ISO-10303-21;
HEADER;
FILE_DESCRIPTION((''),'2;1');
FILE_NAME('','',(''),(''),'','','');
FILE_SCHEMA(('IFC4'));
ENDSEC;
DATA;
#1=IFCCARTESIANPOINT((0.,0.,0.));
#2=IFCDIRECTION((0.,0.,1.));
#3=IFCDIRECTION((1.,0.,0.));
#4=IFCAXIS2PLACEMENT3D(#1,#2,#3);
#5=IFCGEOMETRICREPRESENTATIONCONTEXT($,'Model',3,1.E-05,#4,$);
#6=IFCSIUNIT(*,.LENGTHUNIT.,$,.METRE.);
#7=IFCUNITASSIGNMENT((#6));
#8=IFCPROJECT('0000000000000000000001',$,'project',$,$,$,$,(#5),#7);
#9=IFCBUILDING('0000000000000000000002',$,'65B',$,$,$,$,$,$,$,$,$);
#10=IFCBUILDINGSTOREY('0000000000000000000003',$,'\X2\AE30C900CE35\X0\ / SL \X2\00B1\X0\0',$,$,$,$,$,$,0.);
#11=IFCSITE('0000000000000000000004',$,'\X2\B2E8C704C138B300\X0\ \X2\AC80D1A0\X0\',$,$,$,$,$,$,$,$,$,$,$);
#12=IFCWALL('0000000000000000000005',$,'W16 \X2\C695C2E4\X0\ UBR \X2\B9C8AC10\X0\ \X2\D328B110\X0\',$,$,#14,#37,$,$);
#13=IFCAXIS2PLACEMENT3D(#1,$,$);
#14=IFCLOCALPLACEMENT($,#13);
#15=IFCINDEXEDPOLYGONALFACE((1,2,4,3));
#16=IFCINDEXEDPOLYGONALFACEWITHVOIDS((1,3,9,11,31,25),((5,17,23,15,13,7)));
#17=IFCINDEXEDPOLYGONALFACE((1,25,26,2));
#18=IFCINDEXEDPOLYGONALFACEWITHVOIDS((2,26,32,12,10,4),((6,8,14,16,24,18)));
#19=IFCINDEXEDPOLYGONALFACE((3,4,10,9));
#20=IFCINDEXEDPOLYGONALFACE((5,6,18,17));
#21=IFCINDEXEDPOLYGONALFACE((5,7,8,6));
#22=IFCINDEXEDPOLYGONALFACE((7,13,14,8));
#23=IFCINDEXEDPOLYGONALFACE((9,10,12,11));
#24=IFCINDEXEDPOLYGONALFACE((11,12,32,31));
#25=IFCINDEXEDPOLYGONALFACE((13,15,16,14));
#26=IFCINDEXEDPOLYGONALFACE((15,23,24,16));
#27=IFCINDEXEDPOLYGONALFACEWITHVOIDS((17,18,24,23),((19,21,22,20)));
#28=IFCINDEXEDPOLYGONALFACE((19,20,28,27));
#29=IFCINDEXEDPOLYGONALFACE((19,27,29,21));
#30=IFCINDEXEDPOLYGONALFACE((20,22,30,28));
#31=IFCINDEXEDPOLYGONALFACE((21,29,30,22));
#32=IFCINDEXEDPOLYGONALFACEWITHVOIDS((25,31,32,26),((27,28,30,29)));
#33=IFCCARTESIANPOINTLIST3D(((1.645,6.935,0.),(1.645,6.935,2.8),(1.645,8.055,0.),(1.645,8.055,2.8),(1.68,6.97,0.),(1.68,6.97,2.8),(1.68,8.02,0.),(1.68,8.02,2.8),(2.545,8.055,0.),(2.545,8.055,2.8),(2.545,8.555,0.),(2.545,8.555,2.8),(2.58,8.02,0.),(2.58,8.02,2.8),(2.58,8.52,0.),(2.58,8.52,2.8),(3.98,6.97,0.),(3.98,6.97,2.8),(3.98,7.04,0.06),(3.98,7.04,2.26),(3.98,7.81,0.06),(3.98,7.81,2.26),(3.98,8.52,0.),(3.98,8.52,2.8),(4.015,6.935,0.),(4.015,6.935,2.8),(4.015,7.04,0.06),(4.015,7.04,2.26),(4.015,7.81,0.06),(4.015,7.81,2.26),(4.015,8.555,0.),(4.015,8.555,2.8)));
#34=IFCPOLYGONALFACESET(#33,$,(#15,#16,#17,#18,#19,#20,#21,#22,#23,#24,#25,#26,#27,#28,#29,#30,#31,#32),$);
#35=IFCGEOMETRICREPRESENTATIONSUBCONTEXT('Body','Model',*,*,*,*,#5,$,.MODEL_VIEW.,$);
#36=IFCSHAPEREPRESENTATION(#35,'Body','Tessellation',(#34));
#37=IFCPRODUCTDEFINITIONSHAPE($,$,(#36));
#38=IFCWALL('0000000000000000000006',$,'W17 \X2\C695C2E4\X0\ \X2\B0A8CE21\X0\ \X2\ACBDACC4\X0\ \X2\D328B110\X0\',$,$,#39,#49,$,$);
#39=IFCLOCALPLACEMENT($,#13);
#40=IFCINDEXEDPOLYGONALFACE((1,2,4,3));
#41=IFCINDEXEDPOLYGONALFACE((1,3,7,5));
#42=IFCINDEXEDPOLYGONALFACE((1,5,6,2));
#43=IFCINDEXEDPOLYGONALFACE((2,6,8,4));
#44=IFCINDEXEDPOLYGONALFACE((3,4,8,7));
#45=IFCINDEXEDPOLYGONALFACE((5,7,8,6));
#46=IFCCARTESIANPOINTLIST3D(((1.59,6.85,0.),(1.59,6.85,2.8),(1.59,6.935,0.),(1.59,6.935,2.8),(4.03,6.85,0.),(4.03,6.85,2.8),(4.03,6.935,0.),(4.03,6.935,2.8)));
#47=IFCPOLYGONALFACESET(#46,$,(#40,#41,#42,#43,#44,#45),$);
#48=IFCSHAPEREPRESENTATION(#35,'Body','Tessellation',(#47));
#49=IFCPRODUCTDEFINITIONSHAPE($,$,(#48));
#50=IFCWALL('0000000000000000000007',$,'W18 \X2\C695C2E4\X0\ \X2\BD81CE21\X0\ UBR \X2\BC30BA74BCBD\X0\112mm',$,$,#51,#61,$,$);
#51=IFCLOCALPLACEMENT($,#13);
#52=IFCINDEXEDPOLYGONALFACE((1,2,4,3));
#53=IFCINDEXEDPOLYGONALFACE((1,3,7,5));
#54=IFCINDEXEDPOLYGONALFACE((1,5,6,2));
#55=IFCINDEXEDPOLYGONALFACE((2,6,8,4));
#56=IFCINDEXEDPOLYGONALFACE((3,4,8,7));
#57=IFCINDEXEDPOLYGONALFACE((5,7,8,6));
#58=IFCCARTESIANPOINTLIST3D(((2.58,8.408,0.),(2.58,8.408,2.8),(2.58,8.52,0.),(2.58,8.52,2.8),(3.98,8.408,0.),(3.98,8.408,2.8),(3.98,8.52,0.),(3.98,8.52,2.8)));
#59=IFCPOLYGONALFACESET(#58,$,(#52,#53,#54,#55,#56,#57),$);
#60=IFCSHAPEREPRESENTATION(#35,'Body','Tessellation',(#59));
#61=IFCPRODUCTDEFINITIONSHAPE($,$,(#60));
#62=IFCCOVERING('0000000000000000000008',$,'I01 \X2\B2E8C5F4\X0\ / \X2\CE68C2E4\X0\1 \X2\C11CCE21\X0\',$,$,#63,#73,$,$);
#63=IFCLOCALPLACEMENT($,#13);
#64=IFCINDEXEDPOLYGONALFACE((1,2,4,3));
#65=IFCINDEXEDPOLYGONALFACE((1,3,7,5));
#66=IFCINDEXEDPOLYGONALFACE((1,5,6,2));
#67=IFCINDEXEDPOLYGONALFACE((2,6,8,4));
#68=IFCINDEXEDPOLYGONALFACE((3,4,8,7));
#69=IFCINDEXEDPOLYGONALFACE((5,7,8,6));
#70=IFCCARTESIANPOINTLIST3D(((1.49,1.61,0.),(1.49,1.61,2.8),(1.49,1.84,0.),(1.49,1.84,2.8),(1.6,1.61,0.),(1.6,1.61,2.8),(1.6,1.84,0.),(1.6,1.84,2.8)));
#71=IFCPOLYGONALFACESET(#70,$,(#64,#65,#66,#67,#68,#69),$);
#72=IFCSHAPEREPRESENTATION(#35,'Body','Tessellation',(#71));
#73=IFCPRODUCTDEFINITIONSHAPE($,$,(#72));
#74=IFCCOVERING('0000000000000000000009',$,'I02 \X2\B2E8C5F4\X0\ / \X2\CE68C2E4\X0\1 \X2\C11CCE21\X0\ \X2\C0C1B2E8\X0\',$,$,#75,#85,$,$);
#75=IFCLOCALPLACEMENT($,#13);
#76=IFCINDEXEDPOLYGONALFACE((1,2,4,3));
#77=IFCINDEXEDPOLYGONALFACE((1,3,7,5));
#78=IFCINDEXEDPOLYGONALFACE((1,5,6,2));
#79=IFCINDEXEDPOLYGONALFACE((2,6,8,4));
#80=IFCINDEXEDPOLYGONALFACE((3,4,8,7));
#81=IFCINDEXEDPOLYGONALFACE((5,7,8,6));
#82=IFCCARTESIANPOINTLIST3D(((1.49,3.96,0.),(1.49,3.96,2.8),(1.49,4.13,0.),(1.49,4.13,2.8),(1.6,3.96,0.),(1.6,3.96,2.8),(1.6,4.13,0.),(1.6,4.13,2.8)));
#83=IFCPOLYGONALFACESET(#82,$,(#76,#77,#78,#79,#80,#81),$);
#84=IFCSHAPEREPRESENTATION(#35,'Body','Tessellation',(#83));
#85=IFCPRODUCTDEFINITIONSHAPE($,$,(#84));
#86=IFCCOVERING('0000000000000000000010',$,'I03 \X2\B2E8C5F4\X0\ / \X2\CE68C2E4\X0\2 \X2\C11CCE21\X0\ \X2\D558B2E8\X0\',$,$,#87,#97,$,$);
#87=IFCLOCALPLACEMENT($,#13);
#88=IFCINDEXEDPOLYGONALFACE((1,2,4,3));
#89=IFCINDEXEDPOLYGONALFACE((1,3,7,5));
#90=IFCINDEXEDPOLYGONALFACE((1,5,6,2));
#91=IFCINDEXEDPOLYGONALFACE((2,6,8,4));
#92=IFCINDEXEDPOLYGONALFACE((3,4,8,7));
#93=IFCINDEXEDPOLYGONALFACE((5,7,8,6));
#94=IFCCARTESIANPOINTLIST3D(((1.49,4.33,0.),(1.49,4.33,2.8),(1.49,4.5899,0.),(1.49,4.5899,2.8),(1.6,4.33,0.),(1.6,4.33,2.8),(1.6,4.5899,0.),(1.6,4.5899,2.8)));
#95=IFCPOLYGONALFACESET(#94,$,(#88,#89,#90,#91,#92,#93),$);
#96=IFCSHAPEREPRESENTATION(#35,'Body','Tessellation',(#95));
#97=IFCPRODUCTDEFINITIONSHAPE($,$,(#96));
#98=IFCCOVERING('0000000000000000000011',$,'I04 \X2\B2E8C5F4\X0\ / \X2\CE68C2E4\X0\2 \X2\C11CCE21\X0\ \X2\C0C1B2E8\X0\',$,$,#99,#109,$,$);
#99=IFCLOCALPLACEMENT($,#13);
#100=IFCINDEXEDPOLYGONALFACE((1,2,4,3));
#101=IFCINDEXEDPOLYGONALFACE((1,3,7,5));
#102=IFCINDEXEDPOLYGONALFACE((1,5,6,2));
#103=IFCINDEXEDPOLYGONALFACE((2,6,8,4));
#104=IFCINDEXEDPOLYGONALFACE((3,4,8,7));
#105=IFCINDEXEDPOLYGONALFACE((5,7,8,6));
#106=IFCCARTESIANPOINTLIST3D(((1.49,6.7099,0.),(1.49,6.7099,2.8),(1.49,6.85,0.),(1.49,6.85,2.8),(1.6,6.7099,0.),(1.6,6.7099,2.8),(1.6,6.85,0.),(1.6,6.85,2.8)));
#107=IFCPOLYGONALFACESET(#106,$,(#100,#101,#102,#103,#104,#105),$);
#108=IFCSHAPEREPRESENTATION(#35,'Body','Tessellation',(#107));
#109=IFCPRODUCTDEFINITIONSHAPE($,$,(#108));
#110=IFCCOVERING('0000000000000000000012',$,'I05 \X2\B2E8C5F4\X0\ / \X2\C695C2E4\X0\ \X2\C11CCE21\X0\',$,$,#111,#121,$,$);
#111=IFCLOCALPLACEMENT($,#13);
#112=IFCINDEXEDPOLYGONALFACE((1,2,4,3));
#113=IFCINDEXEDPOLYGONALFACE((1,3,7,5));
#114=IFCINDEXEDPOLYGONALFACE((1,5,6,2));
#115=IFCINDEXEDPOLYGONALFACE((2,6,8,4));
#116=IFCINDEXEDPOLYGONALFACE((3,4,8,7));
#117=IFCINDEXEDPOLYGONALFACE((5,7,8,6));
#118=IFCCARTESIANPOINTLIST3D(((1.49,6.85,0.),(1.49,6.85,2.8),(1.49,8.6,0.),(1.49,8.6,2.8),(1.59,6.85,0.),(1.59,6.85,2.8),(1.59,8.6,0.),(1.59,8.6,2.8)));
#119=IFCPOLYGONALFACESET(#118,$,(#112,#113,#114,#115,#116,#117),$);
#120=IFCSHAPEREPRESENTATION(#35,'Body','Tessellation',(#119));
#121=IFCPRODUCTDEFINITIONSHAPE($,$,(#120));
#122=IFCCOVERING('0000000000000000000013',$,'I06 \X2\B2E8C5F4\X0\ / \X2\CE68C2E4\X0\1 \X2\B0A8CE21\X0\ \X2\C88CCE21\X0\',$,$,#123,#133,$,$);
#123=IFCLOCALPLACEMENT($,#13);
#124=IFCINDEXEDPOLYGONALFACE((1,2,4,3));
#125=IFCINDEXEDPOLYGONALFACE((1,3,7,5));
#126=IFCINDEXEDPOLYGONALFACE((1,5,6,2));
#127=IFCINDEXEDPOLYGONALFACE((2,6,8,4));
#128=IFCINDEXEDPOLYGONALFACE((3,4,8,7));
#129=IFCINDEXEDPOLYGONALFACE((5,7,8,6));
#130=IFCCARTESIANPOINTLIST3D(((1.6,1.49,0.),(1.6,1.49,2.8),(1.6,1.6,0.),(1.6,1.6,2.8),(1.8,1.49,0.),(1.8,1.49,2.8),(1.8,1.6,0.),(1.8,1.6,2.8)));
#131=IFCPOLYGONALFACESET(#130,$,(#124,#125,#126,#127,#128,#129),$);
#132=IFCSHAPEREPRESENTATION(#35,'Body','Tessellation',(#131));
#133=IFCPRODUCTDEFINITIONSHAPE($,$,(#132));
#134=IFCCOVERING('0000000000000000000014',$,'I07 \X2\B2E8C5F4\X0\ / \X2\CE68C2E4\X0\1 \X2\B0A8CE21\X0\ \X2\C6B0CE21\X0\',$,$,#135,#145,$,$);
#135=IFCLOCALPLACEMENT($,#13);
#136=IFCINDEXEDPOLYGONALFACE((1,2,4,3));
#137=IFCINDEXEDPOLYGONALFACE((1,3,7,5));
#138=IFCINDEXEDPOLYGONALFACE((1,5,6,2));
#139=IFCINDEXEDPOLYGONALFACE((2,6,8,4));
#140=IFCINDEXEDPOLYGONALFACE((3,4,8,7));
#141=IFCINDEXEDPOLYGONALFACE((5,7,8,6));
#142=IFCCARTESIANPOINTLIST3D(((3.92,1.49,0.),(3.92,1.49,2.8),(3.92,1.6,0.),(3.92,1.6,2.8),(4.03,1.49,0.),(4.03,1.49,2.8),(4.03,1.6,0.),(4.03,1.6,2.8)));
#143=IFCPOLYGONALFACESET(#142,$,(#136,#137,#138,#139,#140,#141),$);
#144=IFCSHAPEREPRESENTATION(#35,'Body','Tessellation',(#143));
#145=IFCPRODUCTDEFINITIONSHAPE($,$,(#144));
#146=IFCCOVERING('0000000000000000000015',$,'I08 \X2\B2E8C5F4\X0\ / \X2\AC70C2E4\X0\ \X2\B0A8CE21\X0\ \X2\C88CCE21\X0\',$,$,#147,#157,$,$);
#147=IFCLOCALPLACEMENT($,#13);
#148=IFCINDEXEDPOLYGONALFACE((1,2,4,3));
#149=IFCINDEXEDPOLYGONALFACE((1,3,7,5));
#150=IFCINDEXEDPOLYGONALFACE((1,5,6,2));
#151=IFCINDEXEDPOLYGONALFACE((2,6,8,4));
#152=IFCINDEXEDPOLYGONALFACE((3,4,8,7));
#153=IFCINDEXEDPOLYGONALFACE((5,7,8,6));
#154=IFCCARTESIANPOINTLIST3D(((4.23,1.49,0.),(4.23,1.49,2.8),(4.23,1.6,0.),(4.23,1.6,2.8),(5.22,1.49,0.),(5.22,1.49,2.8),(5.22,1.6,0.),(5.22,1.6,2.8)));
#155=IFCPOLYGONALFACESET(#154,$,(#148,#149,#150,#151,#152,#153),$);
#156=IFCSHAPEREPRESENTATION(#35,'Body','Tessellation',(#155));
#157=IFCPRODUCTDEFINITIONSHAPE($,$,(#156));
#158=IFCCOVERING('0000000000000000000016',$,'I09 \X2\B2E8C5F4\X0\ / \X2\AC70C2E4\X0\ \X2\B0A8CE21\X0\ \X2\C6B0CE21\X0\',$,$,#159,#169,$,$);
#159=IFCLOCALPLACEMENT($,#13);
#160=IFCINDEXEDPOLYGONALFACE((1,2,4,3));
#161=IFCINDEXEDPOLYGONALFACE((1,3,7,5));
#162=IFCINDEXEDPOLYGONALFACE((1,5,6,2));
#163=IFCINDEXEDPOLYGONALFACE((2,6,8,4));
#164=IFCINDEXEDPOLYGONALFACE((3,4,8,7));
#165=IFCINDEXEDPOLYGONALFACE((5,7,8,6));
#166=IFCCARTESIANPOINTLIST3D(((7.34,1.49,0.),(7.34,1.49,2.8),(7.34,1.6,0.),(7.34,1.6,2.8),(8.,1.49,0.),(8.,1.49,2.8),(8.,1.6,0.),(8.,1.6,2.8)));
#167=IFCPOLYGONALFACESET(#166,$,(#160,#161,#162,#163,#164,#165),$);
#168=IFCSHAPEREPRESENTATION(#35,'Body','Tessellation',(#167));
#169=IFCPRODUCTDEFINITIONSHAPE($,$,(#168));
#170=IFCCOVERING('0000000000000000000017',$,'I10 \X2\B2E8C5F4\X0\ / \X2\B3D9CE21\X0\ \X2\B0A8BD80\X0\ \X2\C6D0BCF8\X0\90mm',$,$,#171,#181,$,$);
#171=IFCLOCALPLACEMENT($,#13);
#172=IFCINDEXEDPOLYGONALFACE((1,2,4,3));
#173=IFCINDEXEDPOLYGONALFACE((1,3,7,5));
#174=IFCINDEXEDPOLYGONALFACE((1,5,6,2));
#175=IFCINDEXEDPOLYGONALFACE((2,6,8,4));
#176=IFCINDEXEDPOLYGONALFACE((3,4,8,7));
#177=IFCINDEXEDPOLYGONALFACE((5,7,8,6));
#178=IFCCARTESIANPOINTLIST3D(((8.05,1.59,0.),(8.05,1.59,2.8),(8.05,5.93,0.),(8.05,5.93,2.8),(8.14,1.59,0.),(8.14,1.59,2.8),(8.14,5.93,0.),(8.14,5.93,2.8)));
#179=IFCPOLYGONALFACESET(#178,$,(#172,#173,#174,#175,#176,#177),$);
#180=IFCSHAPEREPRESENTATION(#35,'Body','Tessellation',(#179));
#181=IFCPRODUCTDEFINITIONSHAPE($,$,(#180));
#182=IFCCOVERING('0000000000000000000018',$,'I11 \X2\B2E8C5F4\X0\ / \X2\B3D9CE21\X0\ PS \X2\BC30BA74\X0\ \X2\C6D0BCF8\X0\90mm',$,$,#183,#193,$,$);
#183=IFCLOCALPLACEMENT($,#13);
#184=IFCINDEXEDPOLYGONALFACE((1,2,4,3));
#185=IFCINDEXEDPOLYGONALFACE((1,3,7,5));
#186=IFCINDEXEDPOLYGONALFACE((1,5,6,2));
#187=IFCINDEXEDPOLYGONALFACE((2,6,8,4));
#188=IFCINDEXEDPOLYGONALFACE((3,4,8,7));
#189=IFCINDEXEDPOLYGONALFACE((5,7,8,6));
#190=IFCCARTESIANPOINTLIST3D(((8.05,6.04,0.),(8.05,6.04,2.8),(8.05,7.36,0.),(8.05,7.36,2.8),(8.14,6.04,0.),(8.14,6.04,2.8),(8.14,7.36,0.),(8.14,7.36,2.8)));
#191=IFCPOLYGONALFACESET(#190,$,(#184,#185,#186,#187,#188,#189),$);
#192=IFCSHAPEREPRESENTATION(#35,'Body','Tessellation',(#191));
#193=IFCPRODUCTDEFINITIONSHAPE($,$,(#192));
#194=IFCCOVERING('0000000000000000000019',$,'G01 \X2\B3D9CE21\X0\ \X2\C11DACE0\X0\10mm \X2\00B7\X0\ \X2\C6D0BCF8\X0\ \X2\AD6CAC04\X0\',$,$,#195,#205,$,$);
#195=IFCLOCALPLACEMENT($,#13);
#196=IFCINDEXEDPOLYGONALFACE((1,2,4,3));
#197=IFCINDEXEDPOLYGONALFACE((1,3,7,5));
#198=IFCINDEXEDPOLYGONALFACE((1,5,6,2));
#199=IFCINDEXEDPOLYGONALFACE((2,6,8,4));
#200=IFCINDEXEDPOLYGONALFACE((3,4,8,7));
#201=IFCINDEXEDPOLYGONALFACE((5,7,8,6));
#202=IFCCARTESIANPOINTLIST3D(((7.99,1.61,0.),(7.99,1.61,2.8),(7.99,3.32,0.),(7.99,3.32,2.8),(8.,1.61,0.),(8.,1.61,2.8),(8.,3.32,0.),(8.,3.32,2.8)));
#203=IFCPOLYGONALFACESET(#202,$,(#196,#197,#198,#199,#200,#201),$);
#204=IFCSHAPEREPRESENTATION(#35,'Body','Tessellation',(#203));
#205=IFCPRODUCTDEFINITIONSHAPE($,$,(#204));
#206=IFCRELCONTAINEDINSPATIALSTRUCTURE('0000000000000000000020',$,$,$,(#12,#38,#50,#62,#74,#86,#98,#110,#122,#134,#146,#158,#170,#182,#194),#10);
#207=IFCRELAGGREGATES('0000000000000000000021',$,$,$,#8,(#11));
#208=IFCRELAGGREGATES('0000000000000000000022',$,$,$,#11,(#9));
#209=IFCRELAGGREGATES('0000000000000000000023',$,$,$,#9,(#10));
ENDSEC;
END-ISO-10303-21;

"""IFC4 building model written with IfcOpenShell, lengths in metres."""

from ifc_helpers import new_model, si_unit, frame, origin, origin_with_axes, place, context, subcontext, project, spatial, polyline, outline, extrude, element, save


model = new_model("IFC4")

# Units and contexts
model_context = context("Model", 3, precision=1e-05, world=origin_with_axes())
body_context = subcontext(model_context, "Body", "Model", "MODEL_VIEW")
ifc_project = project(units=[si_unit("LENGTHUNIT", "METRE")], contexts=[model_context])

# Site, building, storey
site = spatial("IfcSite", under=ifc_project, Name="단위세대 검토")
building = spatial("IfcBuilding", under=site, Name="65B")
storey = spatial("IfcBuildingStorey", under=building, Name="기준층 / SL ±0", Elevation=0.0)

# Wall, opening
wall_1_placement = place(None, origin_with_axes())
wall_1 = element("IfcWall", 1, at=wall_1_placement, inside=storey, Name="W16 욕실 UBR 마감 패널", context=body_context, shape_type="SweptSolid", body=[
    extrude(outline(polyline([(2.545, 8.555), (4.015, 8.555), (4.015, 6.935), (1.645, 6.935), (1.645, 8.055), (2.545, 8.055), (2.545, 8.555)]), holes=[polyline([(3.98, 6.97), (3.98, 8.52), (2.58, 8.52), (2.58, 8.02), (1.68, 8.02), (1.68, 6.97), (3.98, 6.97)])]), origin(), (0.0, 0.0, 1.0), 2.8),
])
opening_placement = place(wall_1_placement, origin_with_axes())
element("IfcOpeningElement", 2, at=opening_placement, cuts=wall_1, context=body_context, shape_type="SweptSolid", body=[
    extrude(outline(polyline([(4.016, 7.04), (4.016, 7.81), (3.979, 7.81), (3.979, 7.04), (4.016, 7.04)])), frame((0.0, 0.0, 0.06)), (0.0, 0.0, 1.0), 2.2),
])

# Walls
wall_2_placement = place(None, origin_with_axes())
element("IfcWall", 3, at=wall_2_placement, inside=storey, Name="W17 욕실 남측 경계 패널", context=body_context, shape_type="SweptSolid", body=[
    extrude(outline(polyline([(4.03, 6.85), (4.03, 6.935), (1.59, 6.935), (1.59, 6.85), (4.03, 6.85)])), origin(), (0.0, 0.0, 1.0), 2.8),
])
wall_3_placement = place(None, origin_with_axes())
element("IfcWall", 4, at=wall_3_placement, inside=storey, Name="W18 욕실 북측 UBR 배면벽112mm", context=body_context, shape_type="SweptSolid", body=[
    extrude(outline(polyline([(2.58, 8.52), (2.58, 8.408), (3.98, 8.408), (3.98, 8.52), (2.58, 8.52)])), origin(), (0.0, 0.0, 1.0), 2.8),
])

# Coverings
covering_1_placement = place(None, origin_with_axes())
element("IfcCovering", 5, at=covering_1_placement, inside=storey, Name="I01 단열 / 침실1 서측", context=body_context, shape_type="SweptSolid", body=[
    extrude(outline(polyline([(1.6, 1.61), (1.6, 1.84), (1.49, 1.84), (1.49, 1.61), (1.6, 1.61)])), origin(), (0.0, 0.0, 1.0), 2.8),
])
covering_2_placement = place(None, origin_with_axes())
element("IfcCovering", 6, at=covering_2_placement, inside=storey, Name="I02 단열 / 침실1 서측 상단", context=body_context, shape_type="SweptSolid", body=[
    extrude(outline(polyline([(1.6, 3.96), (1.6, 4.13), (1.49, 4.13), (1.49, 3.96), (1.6, 3.96)])), origin(), (0.0, 0.0, 1.0), 2.8),
])
covering_3_placement = place(None, origin_with_axes())
element("IfcCovering", 7, at=covering_3_placement, inside=storey, Name="I03 단열 / 침실2 서측 하단", context=body_context, shape_type="SweptSolid", body=[
    extrude(outline(polyline([(1.6, 4.33), (1.6, 4.5899), (1.49, 4.5899), (1.49, 4.33), (1.6, 4.33)])), origin(), (0.0, 0.0, 1.0), 2.8),
])
covering_4_placement = place(None, origin_with_axes())
element("IfcCovering", 8, at=covering_4_placement, inside=storey, Name="I04 단열 / 침실2 서측 상단", context=body_context, shape_type="SweptSolid", body=[
    extrude(outline(polyline([(1.6, 6.7099), (1.6, 6.85), (1.49, 6.85), (1.49, 6.7099), (1.6, 6.7099)])), origin(), (0.0, 0.0, 1.0), 2.8),
])
covering_5_placement = place(None, origin_with_axes())
element("IfcCovering", 9, at=covering_5_placement, inside=storey, Name="I05 단열 / 욕실 서측", context=body_context, shape_type="SweptSolid", body=[
    extrude(outline(polyline([(1.59, 6.85), (1.59, 8.6), (1.49, 8.6), (1.49, 6.85), (1.59, 6.85)])), origin(), (0.0, 0.0, 1.0), 2.8),
])
covering_6_placement = place(None, origin_with_axes())
element("IfcCovering", 10, at=covering_6_placement, inside=storey, Name="I06 단열 / 침실1 남측 좌측", context=body_context, shape_type="SweptSolid", body=[
    extrude(outline(polyline([(1.8, 1.49), (1.8, 1.6), (1.6, 1.6), (1.6, 1.49), (1.8, 1.49)])), origin(), (0.0, 0.0, 1.0), 2.8),
])
covering_7_placement = place(None, origin_with_axes())
element("IfcCovering", 11, at=covering_7_placement, inside=storey, Name="I07 단열 / 침실1 남측 우측", context=body_context, shape_type="SweptSolid", body=[
    extrude(outline(polyline([(4.03, 1.49), (4.03, 1.6), (3.92, 1.6), (3.92, 1.49), (4.03, 1.49)])), origin(), (0.0, 0.0, 1.0), 2.8),
])
covering_8_placement = place(None, origin_with_axes())
element("IfcCovering", 12, at=covering_8_placement, inside=storey, Name="I08 단열 / 거실 남측 좌측", context=body_context, shape_type="SweptSolid", body=[
    extrude(outline(polyline([(5.22, 1.49), (5.22, 1.6), (4.23, 1.6), (4.23, 1.49), (5.22, 1.49)])), origin(), (0.0, 0.0, 1.0), 2.8),
])
covering_9_placement = place(None, origin_with_axes())
element("IfcCovering", 13, at=covering_9_placement, inside=storey, Name="I09 단열 / 거실 남측 우측", context=body_context, shape_type="SweptSolid", body=[
    extrude(outline(polyline([(8.0, 1.49), (8.0, 1.6), (7.34, 1.6), (7.34, 1.49), (8.0, 1.49)])), origin(), (0.0, 0.0, 1.0), 2.8),
])
covering_10_placement = place(None, origin_with_axes())
element("IfcCovering", 14, at=covering_10_placement, inside=storey, Name="I10 단열 / 동측 남부 원본90mm", context=body_context, shape_type="SweptSolid", body=[
    extrude(outline(polyline([(8.14, 1.59), (8.14, 5.93), (8.05, 5.93), (8.05, 1.59), (8.14, 1.59)])), origin(), (0.0, 0.0, 1.0), 2.8),
])
covering_11_placement = place(None, origin_with_axes())
element("IfcCovering", 15, at=covering_11_placement, inside=storey, Name="I11 단열 / 동측 PS 배면 원본90mm", context=body_context, shape_type="SweptSolid", body=[
    extrude(outline(polyline([(8.14, 6.04), (8.14, 7.36), (8.05, 7.36), (8.05, 6.04), (8.14, 6.04)])), origin(), (0.0, 0.0, 1.0), 2.8),
])
covering_12_placement = place(None, origin_with_axes())
element("IfcCovering", 16, at=covering_12_placement, inside=storey, Name="G01 동측 석고10mm · 원본 구간", context=body_context, shape_type="SweptSolid", body=[
    extrude(outline(polyline([(8.0, 1.61), (8.0, 3.32), (7.99, 3.32), (7.99, 1.61), (8.0, 1.61)])), origin(), (0.0, 0.0, 1.0), 2.8),
])

save(model, "model.ifc")
